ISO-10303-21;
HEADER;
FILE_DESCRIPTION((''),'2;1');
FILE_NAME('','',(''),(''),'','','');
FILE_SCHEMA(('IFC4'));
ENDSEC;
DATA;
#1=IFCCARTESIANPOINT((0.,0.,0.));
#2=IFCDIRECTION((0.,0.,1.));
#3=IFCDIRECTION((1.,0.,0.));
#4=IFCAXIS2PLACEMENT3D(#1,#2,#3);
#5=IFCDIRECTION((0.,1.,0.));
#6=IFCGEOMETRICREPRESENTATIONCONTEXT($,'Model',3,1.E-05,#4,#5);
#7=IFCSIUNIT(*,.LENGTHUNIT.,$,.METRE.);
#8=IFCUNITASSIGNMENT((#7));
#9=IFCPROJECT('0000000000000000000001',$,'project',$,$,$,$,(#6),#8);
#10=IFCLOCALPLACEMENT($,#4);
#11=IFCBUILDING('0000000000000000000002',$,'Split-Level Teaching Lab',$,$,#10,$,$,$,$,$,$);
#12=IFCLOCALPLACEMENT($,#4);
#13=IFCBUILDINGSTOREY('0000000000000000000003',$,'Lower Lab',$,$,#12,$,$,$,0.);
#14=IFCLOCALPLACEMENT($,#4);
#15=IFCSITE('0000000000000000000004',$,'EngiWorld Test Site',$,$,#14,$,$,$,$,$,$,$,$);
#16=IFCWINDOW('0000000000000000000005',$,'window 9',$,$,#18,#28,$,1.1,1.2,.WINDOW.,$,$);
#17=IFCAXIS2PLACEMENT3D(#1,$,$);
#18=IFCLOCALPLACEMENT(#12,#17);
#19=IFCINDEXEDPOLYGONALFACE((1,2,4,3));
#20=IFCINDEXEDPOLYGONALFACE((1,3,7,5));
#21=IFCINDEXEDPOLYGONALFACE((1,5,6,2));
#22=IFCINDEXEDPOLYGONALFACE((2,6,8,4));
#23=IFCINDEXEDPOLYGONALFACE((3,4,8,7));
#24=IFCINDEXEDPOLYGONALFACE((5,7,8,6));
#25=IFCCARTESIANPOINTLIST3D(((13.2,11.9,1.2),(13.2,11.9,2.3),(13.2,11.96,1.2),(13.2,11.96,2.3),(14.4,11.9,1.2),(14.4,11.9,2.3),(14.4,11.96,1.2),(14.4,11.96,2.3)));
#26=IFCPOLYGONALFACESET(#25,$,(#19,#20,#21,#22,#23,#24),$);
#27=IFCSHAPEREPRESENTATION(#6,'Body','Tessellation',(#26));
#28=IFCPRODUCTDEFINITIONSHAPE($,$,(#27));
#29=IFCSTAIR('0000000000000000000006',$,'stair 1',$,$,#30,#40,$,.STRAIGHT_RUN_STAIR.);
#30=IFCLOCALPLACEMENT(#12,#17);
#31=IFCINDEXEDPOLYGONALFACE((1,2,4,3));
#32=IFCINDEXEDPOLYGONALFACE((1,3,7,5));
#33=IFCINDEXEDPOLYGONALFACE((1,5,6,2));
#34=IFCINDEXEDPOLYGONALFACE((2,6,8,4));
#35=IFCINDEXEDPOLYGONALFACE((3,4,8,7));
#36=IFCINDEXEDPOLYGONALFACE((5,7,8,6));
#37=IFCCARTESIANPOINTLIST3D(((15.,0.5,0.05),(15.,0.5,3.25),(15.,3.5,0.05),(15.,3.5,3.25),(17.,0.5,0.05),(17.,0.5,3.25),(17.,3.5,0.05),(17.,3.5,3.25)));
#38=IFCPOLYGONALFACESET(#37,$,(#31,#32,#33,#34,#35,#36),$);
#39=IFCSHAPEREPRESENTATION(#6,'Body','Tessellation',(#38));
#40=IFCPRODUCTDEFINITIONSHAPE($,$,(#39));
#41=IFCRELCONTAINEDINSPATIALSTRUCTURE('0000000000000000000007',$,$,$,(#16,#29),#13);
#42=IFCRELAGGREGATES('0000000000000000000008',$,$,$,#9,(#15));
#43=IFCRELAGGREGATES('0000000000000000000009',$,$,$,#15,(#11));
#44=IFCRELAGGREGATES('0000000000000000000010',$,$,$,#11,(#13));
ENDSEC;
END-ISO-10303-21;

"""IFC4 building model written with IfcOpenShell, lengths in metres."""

from ifc_helpers import new_model, si_unit, direction, frame, origin_with_axes, origin_2d_with_axis, place, context, project, spatial, rectangle, extrude, element, save


model = new_model("IFC4")

# Units and contexts
model_context = context("Model", 3, precision=1e-05, world=origin_with_axes(), true_north=direction((0.0, 1.0, 0.0)))
ifc_project = project(units=[si_unit("LENGTHUNIT", "METRE")], contexts=[model_context])

# Site, building, storey
site_placement = place(None, origin_with_axes())
site = spatial("IfcSite", under=ifc_project, at=site_placement, Name="EngiWorld Test Site")
building_placement = place(None, origin_with_axes())
building = spatial("IfcBuilding", under=site, at=building_placement, Name="Split-Level Teaching Lab")
storey_placement = place(None, origin_with_axes())
storey = spatial("IfcBuildingStorey", under=building, at=storey_placement, Name="Lower Lab", Elevation=0.0)

# Window
for number, where, z_axis, x_axis, name in (
    (1, (13.8, 11.93, 1.2), (0.0, 0.0, 1.0), (1.0, 0.0, 0.0), "window 9"),
):
    element("IfcWindow", number, at=place(None, frame(where, z_axis=z_axis, x_axis=x_axis)), inside=storey, Name=name, OverallHeight=1.1, OverallWidth=1.2, PredefinedType="WINDOW", context=model_context, shape_type="SweptSolid", body=[
        extrude(rectangle(XDim=1.2, YDim=0.06, at=origin_2d_with_axis()), origin_with_axes(), (0.0, 0.0, 1.0), 1.1),
    ])

# Stair
stair_placement = place(None, frame((16.0, 2.0, 0.05), z_axis=(0.0, 0.0, 1.0), x_axis=(1.0, 0.0, 0.0)))
element("IfcStair", 2, at=stair_placement, inside=storey, Name="stair 1", PredefinedType="STRAIGHT_RUN_STAIR", context=model_context, shape_type="SweptSolid", body=[
    extrude(rectangle(XDim=2.0, YDim=3.0, at=origin_2d_with_axis()), origin_with_axes(), (0.0, 0.0, 1.0), 3.2),
])

save(model, "model.ifc")
